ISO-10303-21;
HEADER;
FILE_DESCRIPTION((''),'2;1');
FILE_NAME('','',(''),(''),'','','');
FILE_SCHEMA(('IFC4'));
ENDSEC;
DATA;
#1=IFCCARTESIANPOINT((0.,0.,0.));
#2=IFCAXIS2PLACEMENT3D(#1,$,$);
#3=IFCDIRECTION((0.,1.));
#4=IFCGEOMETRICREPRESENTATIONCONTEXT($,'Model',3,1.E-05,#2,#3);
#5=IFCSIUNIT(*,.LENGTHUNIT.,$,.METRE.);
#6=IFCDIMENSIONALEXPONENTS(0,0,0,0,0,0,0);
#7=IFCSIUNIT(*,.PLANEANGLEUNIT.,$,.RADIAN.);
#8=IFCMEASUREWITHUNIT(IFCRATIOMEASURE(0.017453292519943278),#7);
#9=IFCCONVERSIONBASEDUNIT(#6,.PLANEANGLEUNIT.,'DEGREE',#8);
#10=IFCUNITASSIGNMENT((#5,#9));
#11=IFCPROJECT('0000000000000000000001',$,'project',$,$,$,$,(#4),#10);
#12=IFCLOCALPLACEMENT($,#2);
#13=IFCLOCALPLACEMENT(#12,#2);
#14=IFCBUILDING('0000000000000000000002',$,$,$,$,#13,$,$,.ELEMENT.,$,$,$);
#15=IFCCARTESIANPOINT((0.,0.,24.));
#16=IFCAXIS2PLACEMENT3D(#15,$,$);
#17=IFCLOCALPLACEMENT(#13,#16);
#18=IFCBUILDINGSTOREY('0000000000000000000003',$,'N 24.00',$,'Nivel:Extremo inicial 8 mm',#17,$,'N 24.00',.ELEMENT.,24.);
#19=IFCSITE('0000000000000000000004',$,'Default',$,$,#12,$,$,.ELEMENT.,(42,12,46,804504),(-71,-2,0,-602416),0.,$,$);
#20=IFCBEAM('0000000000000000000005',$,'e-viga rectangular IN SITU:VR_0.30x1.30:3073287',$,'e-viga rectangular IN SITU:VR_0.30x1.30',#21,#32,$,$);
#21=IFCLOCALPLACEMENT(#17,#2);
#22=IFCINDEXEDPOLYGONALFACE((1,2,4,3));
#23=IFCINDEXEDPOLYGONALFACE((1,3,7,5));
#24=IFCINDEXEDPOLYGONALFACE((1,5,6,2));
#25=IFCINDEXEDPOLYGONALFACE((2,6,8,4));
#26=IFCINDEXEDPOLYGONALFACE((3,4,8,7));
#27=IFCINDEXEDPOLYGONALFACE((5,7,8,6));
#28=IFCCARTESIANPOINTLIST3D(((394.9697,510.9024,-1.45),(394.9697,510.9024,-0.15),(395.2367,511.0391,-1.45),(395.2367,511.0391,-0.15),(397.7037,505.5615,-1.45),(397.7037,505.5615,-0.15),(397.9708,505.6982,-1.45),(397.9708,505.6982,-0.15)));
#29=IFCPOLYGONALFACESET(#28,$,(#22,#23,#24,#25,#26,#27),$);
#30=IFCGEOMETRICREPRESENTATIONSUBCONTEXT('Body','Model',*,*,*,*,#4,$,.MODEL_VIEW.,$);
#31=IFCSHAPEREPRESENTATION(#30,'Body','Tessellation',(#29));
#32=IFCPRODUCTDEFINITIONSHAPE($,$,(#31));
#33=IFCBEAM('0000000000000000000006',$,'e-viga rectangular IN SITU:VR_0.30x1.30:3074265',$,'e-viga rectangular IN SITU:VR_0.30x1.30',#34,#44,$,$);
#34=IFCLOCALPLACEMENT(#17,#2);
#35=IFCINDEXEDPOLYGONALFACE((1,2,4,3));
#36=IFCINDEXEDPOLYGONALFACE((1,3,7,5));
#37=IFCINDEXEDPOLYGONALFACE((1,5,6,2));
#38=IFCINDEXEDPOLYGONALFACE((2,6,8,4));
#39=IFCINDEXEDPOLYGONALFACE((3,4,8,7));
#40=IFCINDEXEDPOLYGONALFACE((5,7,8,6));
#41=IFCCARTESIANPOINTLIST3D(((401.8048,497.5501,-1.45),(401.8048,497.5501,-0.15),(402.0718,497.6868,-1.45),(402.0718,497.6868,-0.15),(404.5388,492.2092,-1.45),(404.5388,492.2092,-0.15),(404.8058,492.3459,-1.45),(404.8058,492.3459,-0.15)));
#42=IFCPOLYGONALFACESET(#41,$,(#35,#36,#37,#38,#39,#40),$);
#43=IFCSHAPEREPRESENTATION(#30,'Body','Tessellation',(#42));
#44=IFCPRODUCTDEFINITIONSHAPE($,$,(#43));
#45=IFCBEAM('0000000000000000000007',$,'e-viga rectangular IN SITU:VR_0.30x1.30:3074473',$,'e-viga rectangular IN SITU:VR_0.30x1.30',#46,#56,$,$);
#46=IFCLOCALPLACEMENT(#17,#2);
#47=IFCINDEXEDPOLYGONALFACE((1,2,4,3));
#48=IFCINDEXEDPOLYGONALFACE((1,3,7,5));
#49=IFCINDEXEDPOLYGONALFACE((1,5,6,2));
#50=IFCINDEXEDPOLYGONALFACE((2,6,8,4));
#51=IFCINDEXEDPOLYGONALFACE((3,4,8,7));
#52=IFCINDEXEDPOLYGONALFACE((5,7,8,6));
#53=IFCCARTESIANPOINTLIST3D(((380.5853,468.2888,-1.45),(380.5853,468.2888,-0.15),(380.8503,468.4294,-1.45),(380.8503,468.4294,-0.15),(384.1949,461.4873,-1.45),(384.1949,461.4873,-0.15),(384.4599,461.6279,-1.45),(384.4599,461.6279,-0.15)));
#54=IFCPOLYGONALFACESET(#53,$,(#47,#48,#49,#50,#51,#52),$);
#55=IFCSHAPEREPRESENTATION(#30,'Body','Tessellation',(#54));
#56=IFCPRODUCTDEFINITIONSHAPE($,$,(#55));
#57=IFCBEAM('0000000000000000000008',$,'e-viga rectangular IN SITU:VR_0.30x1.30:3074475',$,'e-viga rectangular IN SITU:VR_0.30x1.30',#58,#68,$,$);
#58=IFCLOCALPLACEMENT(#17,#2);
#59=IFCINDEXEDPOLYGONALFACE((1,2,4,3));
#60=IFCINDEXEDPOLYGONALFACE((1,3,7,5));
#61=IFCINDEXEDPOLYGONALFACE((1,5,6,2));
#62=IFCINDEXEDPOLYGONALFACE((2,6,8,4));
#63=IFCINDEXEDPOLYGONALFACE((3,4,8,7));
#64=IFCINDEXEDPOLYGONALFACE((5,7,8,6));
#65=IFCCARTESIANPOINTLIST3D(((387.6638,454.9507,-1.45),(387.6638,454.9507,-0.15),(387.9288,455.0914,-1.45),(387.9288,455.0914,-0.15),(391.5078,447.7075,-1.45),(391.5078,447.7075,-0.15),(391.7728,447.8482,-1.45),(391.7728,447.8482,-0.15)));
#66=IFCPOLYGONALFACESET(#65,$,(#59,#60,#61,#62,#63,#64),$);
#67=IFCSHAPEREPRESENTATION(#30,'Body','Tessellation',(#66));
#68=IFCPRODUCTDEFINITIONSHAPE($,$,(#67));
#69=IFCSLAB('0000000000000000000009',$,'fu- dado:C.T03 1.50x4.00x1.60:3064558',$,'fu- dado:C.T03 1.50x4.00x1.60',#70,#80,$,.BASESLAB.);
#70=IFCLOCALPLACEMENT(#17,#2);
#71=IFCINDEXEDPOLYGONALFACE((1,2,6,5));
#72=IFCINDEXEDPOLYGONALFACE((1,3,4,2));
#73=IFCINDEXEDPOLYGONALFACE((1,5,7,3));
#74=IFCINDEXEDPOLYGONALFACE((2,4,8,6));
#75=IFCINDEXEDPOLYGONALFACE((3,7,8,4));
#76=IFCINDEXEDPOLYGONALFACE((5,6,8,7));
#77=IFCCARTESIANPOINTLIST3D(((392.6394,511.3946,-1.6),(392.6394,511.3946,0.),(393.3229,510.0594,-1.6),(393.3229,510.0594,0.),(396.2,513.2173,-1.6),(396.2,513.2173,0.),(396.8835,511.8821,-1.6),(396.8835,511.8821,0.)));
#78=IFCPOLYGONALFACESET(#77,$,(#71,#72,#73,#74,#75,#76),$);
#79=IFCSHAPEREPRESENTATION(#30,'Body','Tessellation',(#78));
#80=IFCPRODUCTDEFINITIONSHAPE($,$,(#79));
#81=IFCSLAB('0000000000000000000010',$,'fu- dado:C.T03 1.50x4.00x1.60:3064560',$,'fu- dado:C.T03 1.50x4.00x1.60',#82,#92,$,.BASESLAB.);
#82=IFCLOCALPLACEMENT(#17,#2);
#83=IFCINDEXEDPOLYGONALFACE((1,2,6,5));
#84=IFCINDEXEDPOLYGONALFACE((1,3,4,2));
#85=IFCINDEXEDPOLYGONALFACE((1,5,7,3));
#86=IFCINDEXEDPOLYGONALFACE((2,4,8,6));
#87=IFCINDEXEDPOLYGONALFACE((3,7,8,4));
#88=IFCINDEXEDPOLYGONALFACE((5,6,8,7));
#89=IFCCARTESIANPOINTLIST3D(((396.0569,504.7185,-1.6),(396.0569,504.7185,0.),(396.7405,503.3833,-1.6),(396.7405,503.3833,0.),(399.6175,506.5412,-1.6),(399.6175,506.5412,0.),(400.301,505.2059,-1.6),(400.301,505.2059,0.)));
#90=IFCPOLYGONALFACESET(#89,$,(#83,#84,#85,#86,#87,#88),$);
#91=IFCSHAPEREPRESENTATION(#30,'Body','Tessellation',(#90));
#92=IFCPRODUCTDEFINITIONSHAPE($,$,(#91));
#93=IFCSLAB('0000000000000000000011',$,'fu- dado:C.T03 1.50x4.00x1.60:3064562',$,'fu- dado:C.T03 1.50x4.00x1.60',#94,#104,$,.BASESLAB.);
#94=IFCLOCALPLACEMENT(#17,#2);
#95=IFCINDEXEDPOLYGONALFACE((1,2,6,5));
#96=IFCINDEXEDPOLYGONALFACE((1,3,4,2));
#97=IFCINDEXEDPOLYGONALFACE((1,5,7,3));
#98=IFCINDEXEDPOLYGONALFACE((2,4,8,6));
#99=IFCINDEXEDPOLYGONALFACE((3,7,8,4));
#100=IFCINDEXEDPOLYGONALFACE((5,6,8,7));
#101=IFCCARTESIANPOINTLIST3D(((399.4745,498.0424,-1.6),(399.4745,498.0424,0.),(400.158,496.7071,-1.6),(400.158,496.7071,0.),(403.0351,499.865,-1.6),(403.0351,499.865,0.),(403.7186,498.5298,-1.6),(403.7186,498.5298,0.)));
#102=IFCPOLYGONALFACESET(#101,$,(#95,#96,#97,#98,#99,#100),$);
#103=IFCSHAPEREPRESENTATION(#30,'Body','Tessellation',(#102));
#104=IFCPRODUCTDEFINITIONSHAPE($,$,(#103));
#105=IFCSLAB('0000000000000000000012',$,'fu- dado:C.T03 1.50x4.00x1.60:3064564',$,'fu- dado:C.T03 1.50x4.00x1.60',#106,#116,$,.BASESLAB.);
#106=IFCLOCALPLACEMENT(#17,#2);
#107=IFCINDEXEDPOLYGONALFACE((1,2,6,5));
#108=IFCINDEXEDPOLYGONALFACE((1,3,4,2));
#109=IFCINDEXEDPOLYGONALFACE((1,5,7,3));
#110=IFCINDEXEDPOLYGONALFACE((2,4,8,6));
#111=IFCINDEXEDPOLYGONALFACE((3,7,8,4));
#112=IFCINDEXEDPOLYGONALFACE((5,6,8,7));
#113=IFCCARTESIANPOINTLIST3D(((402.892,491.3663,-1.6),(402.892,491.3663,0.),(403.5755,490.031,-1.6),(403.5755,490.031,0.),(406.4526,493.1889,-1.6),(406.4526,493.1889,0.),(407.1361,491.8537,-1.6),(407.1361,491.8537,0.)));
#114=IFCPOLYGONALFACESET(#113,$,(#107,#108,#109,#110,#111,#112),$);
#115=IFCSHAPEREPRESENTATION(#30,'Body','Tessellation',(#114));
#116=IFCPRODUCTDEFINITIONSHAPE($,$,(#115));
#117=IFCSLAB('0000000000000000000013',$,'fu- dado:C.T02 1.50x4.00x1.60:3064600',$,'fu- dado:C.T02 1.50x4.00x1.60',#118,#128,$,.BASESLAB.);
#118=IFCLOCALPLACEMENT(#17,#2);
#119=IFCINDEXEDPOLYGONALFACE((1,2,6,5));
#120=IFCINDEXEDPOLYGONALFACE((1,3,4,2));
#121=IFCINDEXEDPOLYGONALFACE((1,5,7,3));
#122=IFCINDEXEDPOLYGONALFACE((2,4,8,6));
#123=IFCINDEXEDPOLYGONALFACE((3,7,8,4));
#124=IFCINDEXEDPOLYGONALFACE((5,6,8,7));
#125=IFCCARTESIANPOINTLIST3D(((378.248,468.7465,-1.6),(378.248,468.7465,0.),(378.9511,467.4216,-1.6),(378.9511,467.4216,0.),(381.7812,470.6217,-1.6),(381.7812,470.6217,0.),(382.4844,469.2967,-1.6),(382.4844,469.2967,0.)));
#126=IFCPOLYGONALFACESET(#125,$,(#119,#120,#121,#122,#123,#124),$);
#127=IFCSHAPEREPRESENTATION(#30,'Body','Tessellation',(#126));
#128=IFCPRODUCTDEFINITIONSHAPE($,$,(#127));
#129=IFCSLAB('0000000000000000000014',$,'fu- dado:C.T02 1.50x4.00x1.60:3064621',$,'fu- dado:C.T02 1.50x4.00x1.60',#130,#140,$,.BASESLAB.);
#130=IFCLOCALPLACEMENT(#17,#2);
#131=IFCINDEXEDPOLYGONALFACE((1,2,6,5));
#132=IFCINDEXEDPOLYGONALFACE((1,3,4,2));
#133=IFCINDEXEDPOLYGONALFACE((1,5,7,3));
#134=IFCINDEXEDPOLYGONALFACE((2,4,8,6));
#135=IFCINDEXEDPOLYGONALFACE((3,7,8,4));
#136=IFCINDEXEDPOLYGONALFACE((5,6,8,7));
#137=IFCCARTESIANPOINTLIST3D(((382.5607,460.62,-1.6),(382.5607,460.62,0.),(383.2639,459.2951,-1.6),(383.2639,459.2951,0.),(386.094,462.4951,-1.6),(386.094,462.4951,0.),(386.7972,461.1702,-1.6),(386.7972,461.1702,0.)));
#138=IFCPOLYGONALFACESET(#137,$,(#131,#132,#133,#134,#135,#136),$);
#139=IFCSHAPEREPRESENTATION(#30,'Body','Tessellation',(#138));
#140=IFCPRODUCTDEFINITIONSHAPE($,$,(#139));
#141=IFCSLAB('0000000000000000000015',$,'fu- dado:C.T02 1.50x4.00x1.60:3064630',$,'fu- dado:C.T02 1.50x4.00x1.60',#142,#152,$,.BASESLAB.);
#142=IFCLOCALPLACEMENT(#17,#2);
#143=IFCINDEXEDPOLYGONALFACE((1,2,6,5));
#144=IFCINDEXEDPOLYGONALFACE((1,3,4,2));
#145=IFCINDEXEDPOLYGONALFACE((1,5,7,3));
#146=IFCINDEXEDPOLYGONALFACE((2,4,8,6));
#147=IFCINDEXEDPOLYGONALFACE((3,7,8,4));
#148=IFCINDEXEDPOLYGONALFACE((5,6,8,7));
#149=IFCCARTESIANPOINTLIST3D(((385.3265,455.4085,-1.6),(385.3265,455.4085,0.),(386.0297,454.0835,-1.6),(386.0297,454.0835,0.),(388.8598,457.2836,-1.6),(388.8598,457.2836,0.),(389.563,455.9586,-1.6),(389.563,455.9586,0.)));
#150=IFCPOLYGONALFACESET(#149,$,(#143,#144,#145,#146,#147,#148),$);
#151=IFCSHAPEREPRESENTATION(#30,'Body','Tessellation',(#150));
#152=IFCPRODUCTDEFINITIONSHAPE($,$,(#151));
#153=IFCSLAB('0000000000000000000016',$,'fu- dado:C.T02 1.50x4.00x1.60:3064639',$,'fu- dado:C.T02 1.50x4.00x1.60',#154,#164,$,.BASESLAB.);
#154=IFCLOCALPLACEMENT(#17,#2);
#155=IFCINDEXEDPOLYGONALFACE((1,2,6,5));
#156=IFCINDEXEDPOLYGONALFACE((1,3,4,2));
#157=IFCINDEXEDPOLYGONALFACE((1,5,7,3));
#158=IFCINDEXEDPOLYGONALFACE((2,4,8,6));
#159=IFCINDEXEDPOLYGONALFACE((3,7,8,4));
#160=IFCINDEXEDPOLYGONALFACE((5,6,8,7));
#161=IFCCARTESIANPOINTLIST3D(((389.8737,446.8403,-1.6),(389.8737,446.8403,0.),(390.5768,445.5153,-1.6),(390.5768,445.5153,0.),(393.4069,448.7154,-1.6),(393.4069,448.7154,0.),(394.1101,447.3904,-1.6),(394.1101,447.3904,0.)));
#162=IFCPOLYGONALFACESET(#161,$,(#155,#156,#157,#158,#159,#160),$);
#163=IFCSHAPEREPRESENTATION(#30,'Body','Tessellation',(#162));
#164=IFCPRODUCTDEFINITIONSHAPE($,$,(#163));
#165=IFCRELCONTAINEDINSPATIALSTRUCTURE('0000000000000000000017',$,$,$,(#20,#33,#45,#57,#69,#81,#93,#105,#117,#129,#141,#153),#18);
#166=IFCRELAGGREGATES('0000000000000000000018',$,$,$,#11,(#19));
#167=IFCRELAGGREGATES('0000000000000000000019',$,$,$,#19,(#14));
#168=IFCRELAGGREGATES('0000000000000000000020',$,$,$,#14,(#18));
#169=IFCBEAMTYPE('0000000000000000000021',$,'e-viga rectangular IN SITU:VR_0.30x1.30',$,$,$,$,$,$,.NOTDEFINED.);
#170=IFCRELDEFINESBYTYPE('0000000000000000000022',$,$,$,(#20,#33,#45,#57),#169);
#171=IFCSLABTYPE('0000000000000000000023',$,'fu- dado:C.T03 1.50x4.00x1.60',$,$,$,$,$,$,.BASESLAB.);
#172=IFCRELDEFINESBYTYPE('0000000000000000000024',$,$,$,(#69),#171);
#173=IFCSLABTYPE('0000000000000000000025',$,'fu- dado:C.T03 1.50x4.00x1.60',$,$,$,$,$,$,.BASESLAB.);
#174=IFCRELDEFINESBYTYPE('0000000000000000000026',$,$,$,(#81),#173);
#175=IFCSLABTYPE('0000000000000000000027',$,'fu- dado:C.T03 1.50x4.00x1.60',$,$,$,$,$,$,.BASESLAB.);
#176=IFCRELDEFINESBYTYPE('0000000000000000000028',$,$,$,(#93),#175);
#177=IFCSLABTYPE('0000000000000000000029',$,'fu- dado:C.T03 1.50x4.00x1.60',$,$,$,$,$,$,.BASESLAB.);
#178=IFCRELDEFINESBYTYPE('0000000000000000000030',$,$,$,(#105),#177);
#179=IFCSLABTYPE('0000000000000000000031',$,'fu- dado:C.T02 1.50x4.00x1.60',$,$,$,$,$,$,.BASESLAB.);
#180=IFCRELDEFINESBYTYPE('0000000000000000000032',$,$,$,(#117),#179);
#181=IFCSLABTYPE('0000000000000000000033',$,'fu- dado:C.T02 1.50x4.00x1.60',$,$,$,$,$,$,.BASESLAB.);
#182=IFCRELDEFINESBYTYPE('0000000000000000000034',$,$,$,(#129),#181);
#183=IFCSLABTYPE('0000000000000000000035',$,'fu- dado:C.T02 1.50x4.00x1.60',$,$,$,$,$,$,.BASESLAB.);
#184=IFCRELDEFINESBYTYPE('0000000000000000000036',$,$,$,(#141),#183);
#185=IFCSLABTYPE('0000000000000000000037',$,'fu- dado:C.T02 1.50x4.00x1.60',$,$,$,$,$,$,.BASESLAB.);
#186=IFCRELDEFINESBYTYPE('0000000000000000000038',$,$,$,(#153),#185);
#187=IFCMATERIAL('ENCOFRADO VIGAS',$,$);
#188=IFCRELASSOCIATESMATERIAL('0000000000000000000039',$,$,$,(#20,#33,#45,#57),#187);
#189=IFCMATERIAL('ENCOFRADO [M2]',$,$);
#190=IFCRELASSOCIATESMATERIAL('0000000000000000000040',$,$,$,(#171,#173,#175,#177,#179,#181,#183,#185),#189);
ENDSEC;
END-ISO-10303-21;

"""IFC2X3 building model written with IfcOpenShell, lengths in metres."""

from ifc_helpers import new_model, entity, si_unit, converted_unit, direction, frame, frame_2d, origin, origin_2d_with_axis, place, context, subcontext, project, spatial, rectangle, extrude, material, type_object, element, save


model = new_model("IFC2X3")

# Units and contexts
model_context = context("Model", 3, precision=1e-05, world=origin(), true_north=direction((0.0, 1.0)))
body_context = subcontext(model_context, "Body", "Model", "MODEL_VIEW")
ifc_project = project(units=[si_unit("LENGTHUNIT", "METRE"), converted_unit("PLANEANGLEUNIT", "DEGREE", entity("IfcRatioMeasure", 0.017453292519943278), si_unit("PLANEANGLEUNIT", "RADIAN"), dimensions=[0, 0, 0, 0, 0, 0, 0])], contexts=[model_context])

# Site, building, storey
site_placement = place(None, origin())
site = spatial("IfcSite", under=ifc_project, at=site_placement, Name="Default", CompositionType="ELEMENT", RefLatitude=(42, 12, 46, 804504), RefLongitude=(-71, -2, 0, -602416), RefElevation=0.0)
building_placement = place(site_placement, origin())
building = spatial("IfcBuilding", under=site, at=building_placement, CompositionType="ELEMENT")
storey_placement = place(building_placement, frame((0.0, 0.0, 24.0)))
storey = spatial("IfcBuildingStorey", under=building, at=storey_placement, Name="N 24.00", ObjectType="Nivel:Extremo inicial 8 mm", LongName="N 24.00", CompositionType="ELEMENT", Elevation=24.0)

# Shared definitions
ifc_material_1 = material(Name="ENCOFRADO [M2]")

# Beams
ifc_material_2 = material(Name="ENCOFRADO VIGAS")
beam_type = type_object("IfcBeamType", Name="e-viga rectangular IN SITU:VR_0.30x1.30", PredefinedType="NOTDEFINED")
beam_1_placement = place(storey_placement, frame((395.1032, 510.9707, 0.0), z_axis=(0.0, 0.0, 1.0), x_axis=(0.45567, -0.890149, 0.0)))
element("IfcBeam", 1, at=beam_1_placement, inside=storey, type_object=beam_type, material=ifc_material_2, Name="e-viga rectangular IN SITU:VR_0.30x1.30:3073287", ObjectType="e-viga rectangular IN SITU:VR_0.30x1.30", context=body_context, shape_type="SweptSolid", body=[
    extrude(rectangle(XDim=1.3, YDim=0.3, at=frame_2d((0.0, 0.0), x_axis=(1.0, 0.0))), frame((0.0, 0.0, -0.8), z_axis=(1.0, 0.0, 0.0), x_axis=(0.0, 0.0, -1.0)), (0.0, 0.0, 1.0), 6.0),
])
beam_2_placement = place(storey_placement, frame((401.9383, 497.6185, 0.0), z_axis=(0.0, 0.0, 1.0), x_axis=(0.45567, -0.890149, 0.0)))
element("IfcBeam", 2, at=beam_2_placement, inside=storey, type_object=beam_type, material=ifc_material_2, Name="e-viga rectangular IN SITU:VR_0.30x1.30:3074265", ObjectType="e-viga rectangular IN SITU:VR_0.30x1.30", context=body_context, shape_type="SweptSolid", body=[
    extrude(rectangle(XDim=1.3, YDim=0.3, at=frame_2d((0.0, 0.0), x_axis=(1.0, 0.0))), frame((0.0, 0.0, -0.8), z_axis=(1.0, 0.0, 0.0), x_axis=(0.0, 0.0, -1.0)), (0.0, 0.0, 1.0), 6.0),
])
beam_3_placement = place(storey_placement, frame((380.7178, 468.3591, 0.0), z_axis=(0.0, 0.0, 1.0), x_axis=(0.468777, -0.883316, 0.0)))
element("IfcBeam", 3, at=beam_3_placement, inside=storey, type_object=beam_type, material=ifc_material_2, Name="e-viga rectangular IN SITU:VR_0.30x1.30:3074473", ObjectType="e-viga rectangular IN SITU:VR_0.30x1.30", context=body_context, shape_type="SweptSolid", body=[
    extrude(rectangle(XDim=1.3, YDim=0.3, at=frame_2d((0.0, 0.0), x_axis=(1.0, 0.0))), frame((0.0, 0.0, -0.8), z_axis=(1.0, 0.0, 0.0), x_axis=(0.0, 0.0, -1.0)), (0.0, 0.0, 1.0), 7.7),
])
beam_4_placement = place(storey_placement, frame((387.7963, 455.021, 0.0), z_axis=(0.0, 0.0, 1.0), x_axis=(0.468777, -0.883316, 0.0)))
element("IfcBeam", 4, at=beam_4_placement, inside=storey, type_object=beam_type, material=ifc_material_2, Name="e-viga rectangular IN SITU:VR_0.30x1.30:3074475", ObjectType="e-viga rectangular IN SITU:VR_0.30x1.30", context=body_context, shape_type="SweptSolid", body=[
    extrude(rectangle(XDim=1.3, YDim=0.3, at=origin_2d_with_axis()), frame((0.0, 0.0, -0.8), z_axis=(1.0, 0.0, 0.0), x_axis=(0.0, 0.0, -1.0)), (0.0, 0.0, 1.0), 8.2),
])

# Slabs
slab_type_1 = type_object("IfcSlabType", Name="fu- dado:C.T03 1.50x4.00x1.60", PredefinedType="BASESLAB", material=ifc_material_1)
slab_1_placement = place(storey_placement, origin())
element("IfcSlab", 5, at=slab_1_placement, inside=storey, type_object=slab_type_1, Name="fu- dado:C.T03 1.50x4.00x1.60:3064558", ObjectType="fu- dado:C.T03 1.50x4.00x1.60", PredefinedType="BASESLAB", context=body_context, shape_type="SweptSolid", body=[
    extrude(rectangle(XDim=4.0, YDim=1.5, at=frame_2d((0.0, 0.0), x_axis=(1.0, 0.0))), frame((394.7615, 511.6383, -1.6), z_axis=(0.0, 0.0, 1.0), x_axis=(-0.890149, -0.45567, 0.0)), (0.0, 0.0, 1.0), 1.6),
])
slab_type_2 = type_object("IfcSlabType", Name="fu- dado:C.T03 1.50x4.00x1.60", PredefinedType="BASESLAB", material=ifc_material_1)
slab_2_placement = place(storey_placement, origin())
element("IfcSlab", 6, at=slab_2_placement, inside=storey, type_object=slab_type_2, Name="fu- dado:C.T03 1.50x4.00x1.60:3064560", ObjectType="fu- dado:C.T03 1.50x4.00x1.60", PredefinedType="BASESLAB", context=body_context, shape_type="SweptSolid", body=[
    extrude(rectangle(XDim=4.0, YDim=1.5, at=frame_2d((0.0, 0.0), x_axis=(1.0, 0.0))), frame((398.179, 504.9622, -1.6), z_axis=(0.0, 0.0, 1.0), x_axis=(-0.890149, -0.45567, 0.0)), (0.0, 0.0, 1.0), 1.6),
])
slab_type_3 = type_object("IfcSlabType", Name="fu- dado:C.T03 1.50x4.00x1.60", PredefinedType="BASESLAB", material=ifc_material_1)
slab_3_placement = place(storey_placement, origin())
element("IfcSlab", 7, at=slab_3_placement, inside=storey, type_object=slab_type_3, Name="fu- dado:C.T03 1.50x4.00x1.60:3064562", ObjectType="fu- dado:C.T03 1.50x4.00x1.60", PredefinedType="BASESLAB", context=body_context, shape_type="SweptSolid", body=[
    extrude(rectangle(XDim=4.0, YDim=1.5, at=frame_2d((0.0, 0.0), x_axis=(1.0, 0.0))), frame((401.5965, 498.2861, -1.6), z_axis=(0.0, 0.0, 1.0), x_axis=(-0.890149, -0.45567, 0.0)), (0.0, 0.0, 1.0), 1.6),
])
slab_type_4 = type_object("IfcSlabType", Name="fu- dado:C.T03 1.50x4.00x1.60", PredefinedType="BASESLAB", material=ifc_material_1)
slab_4_placement = place(storey_placement, origin())
element("IfcSlab", 8, at=slab_4_placement, inside=storey, type_object=slab_type_4, Name="fu- dado:C.T03 1.50x4.00x1.60:3064564", ObjectType="fu- dado:C.T03 1.50x4.00x1.60", PredefinedType="BASESLAB", context=body_context, shape_type="SweptSolid", body=[
    extrude(rectangle(XDim=4.0, YDim=1.5, at=frame_2d((0.0, 0.0), x_axis=(1.0, 0.0))), frame((405.014, 491.61, -1.6), z_axis=(0.0, 0.0, 1.0), x_axis=(-0.890149, -0.45567, 0.0)), (0.0, 0.0, 1.0), 1.6),
])
slab_type_5 = type_object("IfcSlabType", Name="fu- dado:C.T02 1.50x4.00x1.60", PredefinedType="BASESLAB", material=ifc_material_1)
slab_5_placement = place(storey_placement, origin())
element("IfcSlab", 9, at=slab_5_placement, inside=storey, type_object=slab_type_5, Name="fu- dado:C.T02 1.50x4.00x1.60:3064600", ObjectType="fu- dado:C.T02 1.50x4.00x1.60", PredefinedType="BASESLAB", context=body_context, shape_type="SweptSolid", body=[
    extrude(rectangle(XDim=4.0, YDim=1.5, at=frame_2d((0.0, 0.0), x_axis=(1.0, 0.0))), frame((380.3662, 469.0216, -1.6), z_axis=(0.0, 0.0, 1.0), x_axis=(-0.883316, -0.468777, 0.0)), (0.0, 0.0, 1.0), 1.6),
])
slab_type_6 = type_object("IfcSlabType", Name="fu- dado:C.T02 1.50x4.00x1.60", PredefinedType="BASESLAB", material=ifc_material_1)
slab_6_placement = place(storey_placement, origin())
element("IfcSlab", 10, at=slab_6_placement, inside=storey, type_object=slab_type_6, Name="fu- dado:C.T02 1.50x4.00x1.60:3064621", ObjectType="fu- dado:C.T02 1.50x4.00x1.60", PredefinedType="BASESLAB", context=body_context, shape_type="SweptSolid", body=[
    extrude(rectangle(XDim=4.0, YDim=1.5, at=frame_2d((0.0, 0.0), x_axis=(1.0, 0.0))), frame((384.6789, 460.8951, -1.6), z_axis=(0.0, 0.0, 1.0), x_axis=(-0.883316, -0.468777, 0.0)), (0.0, 0.0, 1.0), 1.6),
])
slab_type_7 = type_object("IfcSlabType", Name="fu- dado:C.T02 1.50x4.00x1.60", PredefinedType="BASESLAB", material=ifc_material_1)
slab_7_placement = place(storey_placement, origin())
element("IfcSlab", 11, at=slab_7_placement, inside=storey, type_object=slab_type_7, Name="fu- dado:C.T02 1.50x4.00x1.60:3064630", ObjectType="fu- dado:C.T02 1.50x4.00x1.60", PredefinedType="BASESLAB", context=body_context, shape_type="SweptSolid", body=[
    extrude(rectangle(XDim=4.0, YDim=1.5, at=origin_2d_with_axis()), frame((387.4447, 455.6835, -1.6), z_axis=(0.0, 0.0, 1.0), x_axis=(-0.883316, -0.468777, 0.0)), (0.0, 0.0, 1.0), 1.6),
])
slab_type_8 = type_object("IfcSlabType", Name="fu- dado:C.T02 1.50x4.00x1.60", PredefinedType="BASESLAB", material=ifc_material_1)
slab_8_placement = place(storey_placement, origin())
element("IfcSlab", 12, at=slab_8_placement, inside=storey, type_object=slab_type_8, Name="fu- dado:C.T02 1.50x4.00x1.60:3064639", ObjectType="fu- dado:C.T02 1.50x4.00x1.60", PredefinedType="BASESLAB", context=body_context, shape_type="SweptSolid", body=[
    extrude(rectangle(XDim=4.0, YDim=1.5, at=origin_2d_with_axis()), frame((391.9919, 447.1154, -1.6), z_axis=(0.0, 0.0, 1.0), x_axis=(-0.883316, -0.468777, 0.0)), (0.0, 0.0, 1.0), 1.6),
])

save(model, "model.ifc")
